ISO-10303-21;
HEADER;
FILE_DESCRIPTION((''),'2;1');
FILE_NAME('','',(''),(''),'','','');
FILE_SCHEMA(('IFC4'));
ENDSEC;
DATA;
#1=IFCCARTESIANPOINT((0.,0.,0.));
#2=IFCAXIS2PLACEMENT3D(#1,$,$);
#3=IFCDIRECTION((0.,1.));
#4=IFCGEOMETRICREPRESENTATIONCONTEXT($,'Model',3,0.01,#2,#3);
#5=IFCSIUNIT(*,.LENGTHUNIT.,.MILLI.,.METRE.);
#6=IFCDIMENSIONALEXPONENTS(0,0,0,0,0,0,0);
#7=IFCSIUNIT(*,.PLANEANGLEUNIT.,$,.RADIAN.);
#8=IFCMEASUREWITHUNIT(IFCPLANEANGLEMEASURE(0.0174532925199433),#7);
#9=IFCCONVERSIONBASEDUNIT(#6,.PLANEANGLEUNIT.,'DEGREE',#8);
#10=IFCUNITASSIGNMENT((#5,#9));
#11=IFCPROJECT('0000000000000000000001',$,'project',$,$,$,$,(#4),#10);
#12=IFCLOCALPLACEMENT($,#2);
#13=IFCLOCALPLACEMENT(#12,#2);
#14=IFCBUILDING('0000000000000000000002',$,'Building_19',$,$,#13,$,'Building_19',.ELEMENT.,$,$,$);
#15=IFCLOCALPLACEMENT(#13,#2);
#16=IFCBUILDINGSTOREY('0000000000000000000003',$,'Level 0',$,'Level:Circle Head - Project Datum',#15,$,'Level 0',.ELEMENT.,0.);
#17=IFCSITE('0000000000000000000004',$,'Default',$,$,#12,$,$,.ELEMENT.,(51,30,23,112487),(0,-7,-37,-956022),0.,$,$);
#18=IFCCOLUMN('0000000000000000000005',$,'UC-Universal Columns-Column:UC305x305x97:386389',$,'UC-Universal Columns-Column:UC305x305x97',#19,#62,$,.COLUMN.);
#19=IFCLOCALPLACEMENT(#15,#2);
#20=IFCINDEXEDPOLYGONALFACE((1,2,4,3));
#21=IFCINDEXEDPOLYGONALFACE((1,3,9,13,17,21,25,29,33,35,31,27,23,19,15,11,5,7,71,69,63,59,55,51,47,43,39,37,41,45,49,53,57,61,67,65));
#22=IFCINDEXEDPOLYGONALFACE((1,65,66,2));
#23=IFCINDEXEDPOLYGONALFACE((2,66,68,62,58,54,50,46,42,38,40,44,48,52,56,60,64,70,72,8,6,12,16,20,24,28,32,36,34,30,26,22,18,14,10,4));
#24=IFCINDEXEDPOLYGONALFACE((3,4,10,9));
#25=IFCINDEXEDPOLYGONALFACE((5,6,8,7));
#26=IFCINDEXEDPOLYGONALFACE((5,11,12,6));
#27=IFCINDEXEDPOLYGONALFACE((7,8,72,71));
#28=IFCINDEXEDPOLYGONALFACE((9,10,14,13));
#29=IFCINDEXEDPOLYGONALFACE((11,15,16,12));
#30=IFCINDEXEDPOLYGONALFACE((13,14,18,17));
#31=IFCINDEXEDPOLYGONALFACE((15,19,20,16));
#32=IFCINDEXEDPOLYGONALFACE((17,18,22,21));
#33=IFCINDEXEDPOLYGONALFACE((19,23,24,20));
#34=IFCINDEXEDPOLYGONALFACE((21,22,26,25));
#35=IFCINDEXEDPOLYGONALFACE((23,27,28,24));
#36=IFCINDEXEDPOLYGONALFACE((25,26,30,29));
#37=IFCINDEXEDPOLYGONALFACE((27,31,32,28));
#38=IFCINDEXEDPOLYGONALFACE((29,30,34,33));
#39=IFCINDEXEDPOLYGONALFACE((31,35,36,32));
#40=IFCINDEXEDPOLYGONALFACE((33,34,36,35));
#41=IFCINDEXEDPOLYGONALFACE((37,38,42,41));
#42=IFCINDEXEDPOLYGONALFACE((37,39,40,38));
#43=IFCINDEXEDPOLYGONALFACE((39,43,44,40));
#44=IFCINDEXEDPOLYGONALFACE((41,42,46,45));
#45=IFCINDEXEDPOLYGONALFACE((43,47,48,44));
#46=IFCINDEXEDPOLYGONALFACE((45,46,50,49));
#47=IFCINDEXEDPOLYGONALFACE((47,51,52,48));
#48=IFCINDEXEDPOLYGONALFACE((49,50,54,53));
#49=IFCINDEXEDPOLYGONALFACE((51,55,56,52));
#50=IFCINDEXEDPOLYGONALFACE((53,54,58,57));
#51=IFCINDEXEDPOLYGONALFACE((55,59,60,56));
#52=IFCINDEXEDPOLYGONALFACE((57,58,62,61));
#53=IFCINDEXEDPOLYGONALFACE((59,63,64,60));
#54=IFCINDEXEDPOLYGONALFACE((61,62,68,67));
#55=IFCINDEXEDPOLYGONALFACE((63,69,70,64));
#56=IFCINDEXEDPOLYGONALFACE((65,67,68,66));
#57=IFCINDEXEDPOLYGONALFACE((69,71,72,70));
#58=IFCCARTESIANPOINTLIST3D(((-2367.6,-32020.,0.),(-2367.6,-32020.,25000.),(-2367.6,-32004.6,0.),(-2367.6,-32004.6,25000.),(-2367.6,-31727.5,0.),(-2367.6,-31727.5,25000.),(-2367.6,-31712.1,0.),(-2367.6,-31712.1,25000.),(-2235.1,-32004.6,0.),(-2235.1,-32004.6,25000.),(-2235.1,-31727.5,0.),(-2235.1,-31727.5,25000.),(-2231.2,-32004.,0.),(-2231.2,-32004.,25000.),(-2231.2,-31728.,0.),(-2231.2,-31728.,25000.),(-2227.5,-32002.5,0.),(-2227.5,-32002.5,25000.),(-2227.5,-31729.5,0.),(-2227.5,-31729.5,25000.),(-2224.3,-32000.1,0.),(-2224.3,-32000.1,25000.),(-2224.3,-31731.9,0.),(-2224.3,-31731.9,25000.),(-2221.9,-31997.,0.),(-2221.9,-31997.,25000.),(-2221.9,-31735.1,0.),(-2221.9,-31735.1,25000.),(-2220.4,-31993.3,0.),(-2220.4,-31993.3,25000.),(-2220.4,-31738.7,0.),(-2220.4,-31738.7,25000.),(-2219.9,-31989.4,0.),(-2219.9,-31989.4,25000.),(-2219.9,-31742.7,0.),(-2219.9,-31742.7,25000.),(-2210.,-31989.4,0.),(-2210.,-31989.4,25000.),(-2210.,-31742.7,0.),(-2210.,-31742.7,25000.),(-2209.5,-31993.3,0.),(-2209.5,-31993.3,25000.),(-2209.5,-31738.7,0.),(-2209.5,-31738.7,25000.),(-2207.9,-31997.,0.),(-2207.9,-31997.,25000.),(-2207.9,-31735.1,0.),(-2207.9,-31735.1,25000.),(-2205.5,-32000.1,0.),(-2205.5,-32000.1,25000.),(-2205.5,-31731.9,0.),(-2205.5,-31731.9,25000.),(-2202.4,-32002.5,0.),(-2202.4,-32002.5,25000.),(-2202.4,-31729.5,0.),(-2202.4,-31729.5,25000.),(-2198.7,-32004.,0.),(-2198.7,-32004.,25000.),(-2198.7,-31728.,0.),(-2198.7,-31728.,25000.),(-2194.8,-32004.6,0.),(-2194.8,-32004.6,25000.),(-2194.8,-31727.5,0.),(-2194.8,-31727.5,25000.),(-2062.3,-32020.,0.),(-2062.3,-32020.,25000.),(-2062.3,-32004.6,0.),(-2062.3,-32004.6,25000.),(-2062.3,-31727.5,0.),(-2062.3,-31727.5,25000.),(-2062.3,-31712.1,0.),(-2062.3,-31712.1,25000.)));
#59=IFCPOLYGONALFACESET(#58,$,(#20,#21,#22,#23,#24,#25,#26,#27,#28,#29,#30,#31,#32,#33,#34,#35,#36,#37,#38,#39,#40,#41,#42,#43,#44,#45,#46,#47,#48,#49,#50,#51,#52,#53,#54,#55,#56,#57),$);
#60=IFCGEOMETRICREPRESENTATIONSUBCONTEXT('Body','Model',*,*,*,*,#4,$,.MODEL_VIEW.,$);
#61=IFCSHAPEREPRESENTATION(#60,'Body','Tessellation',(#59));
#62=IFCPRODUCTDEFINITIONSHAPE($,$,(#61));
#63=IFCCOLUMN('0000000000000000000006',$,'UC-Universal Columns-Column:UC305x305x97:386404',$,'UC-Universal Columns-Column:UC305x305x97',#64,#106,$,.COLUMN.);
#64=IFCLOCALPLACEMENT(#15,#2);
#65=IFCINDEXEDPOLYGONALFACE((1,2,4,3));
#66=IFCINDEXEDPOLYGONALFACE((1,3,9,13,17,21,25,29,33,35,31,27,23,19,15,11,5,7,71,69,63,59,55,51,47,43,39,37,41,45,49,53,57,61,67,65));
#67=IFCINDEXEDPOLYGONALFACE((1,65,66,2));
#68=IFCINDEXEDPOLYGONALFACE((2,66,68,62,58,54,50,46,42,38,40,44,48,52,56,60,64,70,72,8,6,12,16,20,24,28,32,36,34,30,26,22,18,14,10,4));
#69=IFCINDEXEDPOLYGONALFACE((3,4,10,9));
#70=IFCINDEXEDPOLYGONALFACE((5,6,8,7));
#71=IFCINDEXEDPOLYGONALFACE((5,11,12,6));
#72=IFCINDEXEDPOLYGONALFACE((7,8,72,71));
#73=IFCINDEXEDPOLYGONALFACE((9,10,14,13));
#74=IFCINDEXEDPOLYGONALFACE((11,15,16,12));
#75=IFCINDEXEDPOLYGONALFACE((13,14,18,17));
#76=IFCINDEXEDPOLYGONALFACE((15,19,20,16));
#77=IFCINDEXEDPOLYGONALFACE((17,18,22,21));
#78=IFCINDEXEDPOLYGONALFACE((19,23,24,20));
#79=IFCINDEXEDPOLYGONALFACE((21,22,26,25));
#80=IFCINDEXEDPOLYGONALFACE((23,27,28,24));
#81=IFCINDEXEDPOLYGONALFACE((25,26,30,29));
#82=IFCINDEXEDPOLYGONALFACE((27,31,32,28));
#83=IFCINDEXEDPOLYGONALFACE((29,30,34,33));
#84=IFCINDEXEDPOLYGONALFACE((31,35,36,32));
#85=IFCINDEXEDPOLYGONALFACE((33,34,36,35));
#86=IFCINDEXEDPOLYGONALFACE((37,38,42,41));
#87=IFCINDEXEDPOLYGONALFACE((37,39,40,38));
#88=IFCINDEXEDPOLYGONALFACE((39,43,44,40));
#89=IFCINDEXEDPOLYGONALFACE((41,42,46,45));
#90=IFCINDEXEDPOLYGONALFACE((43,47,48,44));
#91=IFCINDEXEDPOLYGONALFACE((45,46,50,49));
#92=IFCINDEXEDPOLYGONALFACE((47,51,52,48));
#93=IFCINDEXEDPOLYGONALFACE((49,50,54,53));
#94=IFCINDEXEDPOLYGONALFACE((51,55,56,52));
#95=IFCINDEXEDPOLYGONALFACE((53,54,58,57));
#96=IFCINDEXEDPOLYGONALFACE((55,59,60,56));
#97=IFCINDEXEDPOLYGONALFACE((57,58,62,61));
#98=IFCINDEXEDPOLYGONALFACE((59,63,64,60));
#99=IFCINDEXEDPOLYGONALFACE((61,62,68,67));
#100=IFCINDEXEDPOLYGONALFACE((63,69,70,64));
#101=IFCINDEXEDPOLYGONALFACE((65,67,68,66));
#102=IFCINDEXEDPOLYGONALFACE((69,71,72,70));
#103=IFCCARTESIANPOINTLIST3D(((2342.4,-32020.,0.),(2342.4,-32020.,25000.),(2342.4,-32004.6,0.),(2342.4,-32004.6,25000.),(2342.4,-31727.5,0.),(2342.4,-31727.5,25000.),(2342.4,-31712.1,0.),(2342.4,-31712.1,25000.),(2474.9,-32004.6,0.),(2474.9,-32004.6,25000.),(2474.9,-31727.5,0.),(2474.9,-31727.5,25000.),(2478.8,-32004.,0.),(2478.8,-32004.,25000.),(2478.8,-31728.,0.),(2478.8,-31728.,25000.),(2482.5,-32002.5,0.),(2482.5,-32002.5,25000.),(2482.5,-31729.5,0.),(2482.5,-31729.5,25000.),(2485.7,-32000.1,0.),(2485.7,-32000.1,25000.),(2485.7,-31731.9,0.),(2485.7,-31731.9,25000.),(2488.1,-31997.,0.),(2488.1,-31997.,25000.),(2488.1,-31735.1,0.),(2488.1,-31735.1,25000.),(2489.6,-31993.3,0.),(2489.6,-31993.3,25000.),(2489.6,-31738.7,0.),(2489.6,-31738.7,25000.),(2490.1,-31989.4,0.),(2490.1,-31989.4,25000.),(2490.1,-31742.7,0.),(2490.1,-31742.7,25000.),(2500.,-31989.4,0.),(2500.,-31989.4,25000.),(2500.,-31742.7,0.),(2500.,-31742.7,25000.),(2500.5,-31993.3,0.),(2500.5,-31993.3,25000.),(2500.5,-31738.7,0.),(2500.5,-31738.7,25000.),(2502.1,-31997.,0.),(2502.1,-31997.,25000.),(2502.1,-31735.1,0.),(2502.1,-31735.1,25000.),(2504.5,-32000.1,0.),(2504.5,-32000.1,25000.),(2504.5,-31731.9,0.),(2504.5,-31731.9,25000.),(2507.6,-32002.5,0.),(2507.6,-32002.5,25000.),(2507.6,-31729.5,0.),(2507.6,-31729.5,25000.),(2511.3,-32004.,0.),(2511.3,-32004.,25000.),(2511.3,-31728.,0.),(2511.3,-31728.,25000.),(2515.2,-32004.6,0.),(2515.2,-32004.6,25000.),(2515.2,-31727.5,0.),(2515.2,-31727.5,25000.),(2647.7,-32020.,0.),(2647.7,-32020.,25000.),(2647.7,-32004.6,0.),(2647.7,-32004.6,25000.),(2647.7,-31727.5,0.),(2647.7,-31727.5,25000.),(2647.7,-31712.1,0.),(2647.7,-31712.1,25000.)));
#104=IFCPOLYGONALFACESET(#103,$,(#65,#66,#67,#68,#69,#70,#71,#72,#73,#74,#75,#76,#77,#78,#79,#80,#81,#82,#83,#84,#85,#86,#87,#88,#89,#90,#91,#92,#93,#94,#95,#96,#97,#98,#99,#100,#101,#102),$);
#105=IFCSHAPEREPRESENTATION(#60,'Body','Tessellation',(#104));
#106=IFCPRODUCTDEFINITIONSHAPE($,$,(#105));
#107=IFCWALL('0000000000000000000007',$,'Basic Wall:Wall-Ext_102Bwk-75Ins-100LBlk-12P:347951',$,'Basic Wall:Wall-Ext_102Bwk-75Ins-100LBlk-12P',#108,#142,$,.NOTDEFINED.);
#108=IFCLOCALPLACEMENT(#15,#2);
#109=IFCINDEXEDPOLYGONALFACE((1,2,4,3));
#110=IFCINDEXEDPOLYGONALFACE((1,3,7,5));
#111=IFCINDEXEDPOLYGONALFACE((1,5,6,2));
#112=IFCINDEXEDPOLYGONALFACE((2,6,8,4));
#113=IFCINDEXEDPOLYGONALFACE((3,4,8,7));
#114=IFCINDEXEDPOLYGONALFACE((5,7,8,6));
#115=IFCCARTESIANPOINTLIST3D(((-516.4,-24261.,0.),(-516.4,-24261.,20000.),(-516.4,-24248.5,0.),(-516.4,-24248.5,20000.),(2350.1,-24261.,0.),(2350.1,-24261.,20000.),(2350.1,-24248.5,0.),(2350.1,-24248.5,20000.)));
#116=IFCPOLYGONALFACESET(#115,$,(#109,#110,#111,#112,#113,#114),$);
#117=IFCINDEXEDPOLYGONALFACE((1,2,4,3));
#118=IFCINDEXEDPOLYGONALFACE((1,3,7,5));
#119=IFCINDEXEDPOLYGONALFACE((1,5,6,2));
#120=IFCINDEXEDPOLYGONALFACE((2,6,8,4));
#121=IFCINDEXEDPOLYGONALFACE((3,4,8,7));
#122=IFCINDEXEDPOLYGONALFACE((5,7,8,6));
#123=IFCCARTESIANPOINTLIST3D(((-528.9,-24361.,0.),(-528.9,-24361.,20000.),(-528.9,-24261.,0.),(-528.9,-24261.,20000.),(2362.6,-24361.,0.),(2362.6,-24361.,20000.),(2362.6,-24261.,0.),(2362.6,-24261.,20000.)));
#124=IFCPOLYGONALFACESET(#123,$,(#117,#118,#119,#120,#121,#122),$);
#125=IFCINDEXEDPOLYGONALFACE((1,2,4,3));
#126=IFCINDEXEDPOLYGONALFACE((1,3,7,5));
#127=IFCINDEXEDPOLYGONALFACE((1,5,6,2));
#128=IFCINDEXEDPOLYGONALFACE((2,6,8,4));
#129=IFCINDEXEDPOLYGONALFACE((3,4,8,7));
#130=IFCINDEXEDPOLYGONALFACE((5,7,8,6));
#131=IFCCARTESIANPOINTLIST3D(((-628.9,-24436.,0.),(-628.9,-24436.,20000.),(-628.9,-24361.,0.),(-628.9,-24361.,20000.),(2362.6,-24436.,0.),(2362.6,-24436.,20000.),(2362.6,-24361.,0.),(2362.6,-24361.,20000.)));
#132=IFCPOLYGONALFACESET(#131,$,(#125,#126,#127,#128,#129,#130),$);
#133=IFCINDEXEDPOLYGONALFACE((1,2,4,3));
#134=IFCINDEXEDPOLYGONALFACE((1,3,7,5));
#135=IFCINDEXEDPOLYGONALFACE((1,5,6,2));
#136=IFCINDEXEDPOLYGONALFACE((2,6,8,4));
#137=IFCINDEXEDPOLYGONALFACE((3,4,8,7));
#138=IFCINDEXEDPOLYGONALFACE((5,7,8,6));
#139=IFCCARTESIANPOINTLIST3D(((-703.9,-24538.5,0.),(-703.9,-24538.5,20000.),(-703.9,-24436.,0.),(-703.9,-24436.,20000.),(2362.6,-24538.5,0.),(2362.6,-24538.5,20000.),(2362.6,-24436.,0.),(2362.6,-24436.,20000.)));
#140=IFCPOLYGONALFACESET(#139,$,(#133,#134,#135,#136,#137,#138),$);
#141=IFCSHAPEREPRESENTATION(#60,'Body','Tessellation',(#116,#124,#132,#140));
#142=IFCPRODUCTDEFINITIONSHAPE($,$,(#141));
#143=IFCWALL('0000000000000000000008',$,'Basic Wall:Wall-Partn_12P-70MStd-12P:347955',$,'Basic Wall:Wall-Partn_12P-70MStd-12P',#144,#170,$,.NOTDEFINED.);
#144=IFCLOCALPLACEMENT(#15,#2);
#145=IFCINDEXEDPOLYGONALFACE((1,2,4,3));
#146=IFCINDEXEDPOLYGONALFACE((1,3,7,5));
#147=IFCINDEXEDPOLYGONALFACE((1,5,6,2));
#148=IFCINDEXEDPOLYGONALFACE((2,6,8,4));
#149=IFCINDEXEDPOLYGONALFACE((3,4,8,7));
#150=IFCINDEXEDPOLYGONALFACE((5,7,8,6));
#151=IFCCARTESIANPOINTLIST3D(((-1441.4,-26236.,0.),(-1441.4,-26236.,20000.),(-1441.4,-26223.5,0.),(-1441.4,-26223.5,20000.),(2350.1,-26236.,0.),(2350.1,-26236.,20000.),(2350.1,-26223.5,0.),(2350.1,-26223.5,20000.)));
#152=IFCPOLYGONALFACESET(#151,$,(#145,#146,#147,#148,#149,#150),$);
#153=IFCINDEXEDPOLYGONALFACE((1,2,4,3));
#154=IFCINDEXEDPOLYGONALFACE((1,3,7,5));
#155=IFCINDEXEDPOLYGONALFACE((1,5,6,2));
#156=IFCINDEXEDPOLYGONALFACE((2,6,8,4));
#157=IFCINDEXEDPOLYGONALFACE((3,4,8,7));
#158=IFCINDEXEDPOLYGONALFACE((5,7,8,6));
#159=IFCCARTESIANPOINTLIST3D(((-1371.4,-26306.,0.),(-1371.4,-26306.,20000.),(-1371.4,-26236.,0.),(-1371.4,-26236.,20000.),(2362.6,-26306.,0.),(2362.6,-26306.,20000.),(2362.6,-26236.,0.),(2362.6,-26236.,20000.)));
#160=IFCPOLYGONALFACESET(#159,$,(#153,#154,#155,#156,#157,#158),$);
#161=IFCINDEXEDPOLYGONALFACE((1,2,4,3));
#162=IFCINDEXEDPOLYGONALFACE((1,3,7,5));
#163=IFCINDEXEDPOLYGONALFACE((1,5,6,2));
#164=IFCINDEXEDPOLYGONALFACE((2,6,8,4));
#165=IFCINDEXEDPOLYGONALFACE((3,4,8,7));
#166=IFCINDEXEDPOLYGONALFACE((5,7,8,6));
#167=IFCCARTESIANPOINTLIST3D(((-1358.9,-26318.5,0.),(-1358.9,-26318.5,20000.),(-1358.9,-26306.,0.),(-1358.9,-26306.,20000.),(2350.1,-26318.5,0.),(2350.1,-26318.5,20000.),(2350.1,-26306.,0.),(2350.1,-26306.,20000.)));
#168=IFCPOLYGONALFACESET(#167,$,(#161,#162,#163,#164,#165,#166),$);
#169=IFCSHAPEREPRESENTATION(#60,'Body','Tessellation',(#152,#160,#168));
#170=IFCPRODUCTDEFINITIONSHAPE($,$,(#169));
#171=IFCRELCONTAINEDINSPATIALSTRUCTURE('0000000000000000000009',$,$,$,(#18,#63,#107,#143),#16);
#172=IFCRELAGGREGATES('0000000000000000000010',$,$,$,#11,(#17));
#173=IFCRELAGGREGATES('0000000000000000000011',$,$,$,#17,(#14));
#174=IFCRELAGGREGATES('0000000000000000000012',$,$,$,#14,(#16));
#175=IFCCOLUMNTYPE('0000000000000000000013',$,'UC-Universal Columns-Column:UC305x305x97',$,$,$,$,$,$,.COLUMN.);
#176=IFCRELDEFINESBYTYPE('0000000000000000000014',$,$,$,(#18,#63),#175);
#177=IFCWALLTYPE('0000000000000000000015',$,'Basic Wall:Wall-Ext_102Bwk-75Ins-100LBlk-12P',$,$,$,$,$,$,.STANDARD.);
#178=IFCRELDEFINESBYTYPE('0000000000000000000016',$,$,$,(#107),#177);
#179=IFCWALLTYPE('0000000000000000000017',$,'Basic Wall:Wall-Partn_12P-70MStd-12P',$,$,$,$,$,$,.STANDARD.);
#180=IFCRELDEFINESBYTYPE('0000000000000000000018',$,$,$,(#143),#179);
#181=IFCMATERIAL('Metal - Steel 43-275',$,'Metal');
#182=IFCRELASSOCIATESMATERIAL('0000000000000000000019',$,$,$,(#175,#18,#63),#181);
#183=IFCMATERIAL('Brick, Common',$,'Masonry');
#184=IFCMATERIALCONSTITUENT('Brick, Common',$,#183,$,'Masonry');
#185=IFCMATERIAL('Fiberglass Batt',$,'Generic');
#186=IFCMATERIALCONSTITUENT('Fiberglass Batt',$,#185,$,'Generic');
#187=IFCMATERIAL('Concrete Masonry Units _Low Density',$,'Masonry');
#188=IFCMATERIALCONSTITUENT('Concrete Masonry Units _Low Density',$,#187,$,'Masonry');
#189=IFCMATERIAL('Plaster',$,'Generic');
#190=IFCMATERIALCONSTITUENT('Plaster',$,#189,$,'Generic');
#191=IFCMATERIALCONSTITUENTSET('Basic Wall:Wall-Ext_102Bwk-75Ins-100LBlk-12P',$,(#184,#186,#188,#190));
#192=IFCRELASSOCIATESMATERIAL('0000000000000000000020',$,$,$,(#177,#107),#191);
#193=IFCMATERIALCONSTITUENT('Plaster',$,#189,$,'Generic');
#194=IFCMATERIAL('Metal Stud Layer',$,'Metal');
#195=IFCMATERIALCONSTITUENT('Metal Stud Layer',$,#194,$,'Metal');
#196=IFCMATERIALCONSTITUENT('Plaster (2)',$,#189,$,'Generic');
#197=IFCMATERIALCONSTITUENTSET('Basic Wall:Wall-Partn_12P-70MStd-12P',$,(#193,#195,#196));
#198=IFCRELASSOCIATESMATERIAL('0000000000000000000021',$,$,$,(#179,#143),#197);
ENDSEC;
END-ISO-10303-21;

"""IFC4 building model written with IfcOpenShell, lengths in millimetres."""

from ifc_helpers import new_model, entity, si_unit, converted_unit, direction, frame, origin, place, context, subcontext, project, spatial, line, arc, indexed_curve, outline, extrude, source, transform, mapped, material, constituent, constituent_set, type_object, type_shapes, element, save


model = new_model("IFC4")

# Units and contexts
model_context = context("Model", 3, precision=0.01, world=origin(), true_north=direction((0.0, 1.0)))
body_context = subcontext(model_context, "Body", "Model", "MODEL_VIEW")
ifc_project = project(units=[si_unit("LENGTHUNIT", "METRE", prefix="MILLI"), converted_unit("PLANEANGLEUNIT", "DEGREE", entity("IfcPlaneAngleMeasure", 0.0174532925199433), si_unit("PLANEANGLEUNIT", "RADIAN"), dimensions=[0, 0, 0, 0, 0, 0, 0])], contexts=[model_context])

# Site, building, storey
site_placement = place(None, origin())
site = spatial("IfcSite", under=ifc_project, at=site_placement, Name="Default", CompositionType="ELEMENT", RefLatitude=(51, 30, 23, 112487), RefLongitude=(0, -7, -37, -956022), RefElevation=0.0)
building_placement = place(site_placement, origin())
building = spatial("IfcBuilding", under=site, at=building_placement, Name="Building_19", LongName="Building_19", CompositionType="ELEMENT")
storey_placement = place(building_placement, origin())
storey = spatial("IfcBuildingStorey", under=building, at=storey_placement, Name="Level 0", ObjectType="Level:Circle Head - Project Datum", LongName="Level 0", CompositionType="ELEMENT", Elevation=0.0)

# Columns
ifc_material_1 = material(Name="Metal - Steel 43-275", Category="Metal")
column_type = type_object("IfcColumnType", Name="UC-Universal Columns-Column:UC305x305x97", PredefinedType="COLUMN", material=ifc_material_1)
shared_shape_1 = source(origin(), body_context, "Body", "SweptSolid", [
    extrude(outline(indexed_curve([(-152.7, -153.9), (152.7, -153.9), (152.7, -138.6), (20.2, -138.6), (9.4, -134.1), (4.9, -123.3), (4.9, 123.3), (9.4, 134.1), (20.1, 138.6), (152.7, 138.6), (152.7, 153.9), (-152.7, 153.9), (-152.7, 138.6), (-20.2, 138.6), (-9.4, 134.1), (-5.0, 123.3), (-5.0, -123.3), (-9.4, -134.1), (-20.2, -138.6), (-152.7, -138.6)], segments=[line(1, 2, 3, 4), arc(4, 5, 6), line(6, 7), arc(7, 8, 9), line(9, 10, 11, 12, 13, 14), arc(14, 15, 16), line(16, 17), arc(17, 18, 19), line(19, 20, 1)], self_intersect=False)), frame((0.0, 0.0, 0.0), z_axis=(0.0, 0.0, 1.0), x_axis=(-1.0, 0.0, 0.0)), (0.0, 0.0, 1.0), 25000.0),
])
type_shapes(column_type, [shared_shape_1])
for number, where, name in (
    (1, (-2214.9, -31866.0, 0.0), "UC-Universal Columns-Column:UC305x305x97:386389"),
    (2, (2495.1, -31866.0, 0.0), "UC-Universal Columns-Column:UC305x305x97:386404"),
):
    element("IfcColumn", number, at=place(storey_placement, frame(where)), inside=storey, type_object=column_type, material=ifc_material_1, Name=name, ObjectType="UC-Universal Columns-Column:UC305x305x97", PredefinedType="COLUMN", context=body_context, shape_type="MappedRepresentation", body=[
        mapped(shared_shape_1, transform((0.0, 0.0, 0.0), scale=1.0)),
    ])

# Shared definitions
ifc_material_2 = material(Name="Brick, Common", Category="Masonry")
ifc_constituent_1 = constituent(ifc_material_2, Name="Brick, Common", Category="Masonry")
ifc_material_3 = material(Name="Fiberglass Batt", Category="Generic")
ifc_constituent_2 = constituent(ifc_material_3, Name="Fiberglass Batt", Category="Generic")
ifc_material_4 = material(Name="Concrete Masonry Units _Low Density", Category="Masonry")
ifc_constituent_3 = constituent(ifc_material_4, Name="Concrete Masonry Units _Low Density", Category="Masonry")
ifc_material_5 = material(Name="Plaster", Category="Generic")
ifc_constituent_4 = constituent(ifc_material_5, Name="Plaster", Category="Generic")
ifc_constituent_set_1 = constituent_set(constituents=[ifc_constituent_1, ifc_constituent_2, ifc_constituent_3, ifc_constituent_4], Name="Basic Wall:Wall-Ext_102Bwk-75Ins-100LBlk-12P")
wall_type_1 = type_object("IfcWallType", Name="Basic Wall:Wall-Ext_102Bwk-75Ins-100LBlk-12P", PredefinedType="STANDARD", material=ifc_constituent_set_1)

# Wall
wall_1_placement = place(storey_placement, frame((-516.4, -24393.5, 0.0)))
element("IfcWall", 3, at=wall_1_placement, inside=storey, type_object=wall_type_1, material=ifc_constituent_set_1, Name="Basic Wall:Wall-Ext_102Bwk-75Ins-100LBlk-12P:347951", ObjectType="Basic Wall:Wall-Ext_102Bwk-75Ins-100LBlk-12P", PredefinedType="NOTDEFINED", context=body_context, shape_type="SweptSolid", body=[
    extrude(outline(indexed_curve([(-6.3, -1433.2), (6.2, -1433.2), (6.3, 1433.2), (-6.2, 1433.2), (-6.3, -1433.2)], self_intersect=False)), frame((1433.2, 138.8, 0.0), z_axis=(0.0, 0.0, 1.0), x_axis=(0.0, -1.0, 0.0)), (0.0, 0.0, 1.0), 20000.0),
    extrude(outline(indexed_curve([(-1445.7, -50.0), (1445.7, -50.0), (1445.7, 50.0), (-1445.7, 50.0), (-1445.7, -50.0)], self_intersect=False)), frame((1433.2, 82.5, 0.0)), (0.0, 0.0, 1.0), 20000.0),
    extrude(outline(indexed_curve([(-1495.7, -37.5), (1495.7, -37.5), (1495.7, 37.5), (-1495.7, 37.5), (-1495.7, -37.5)], self_intersect=False)), frame((1383.2, -5.0, 0.0)), (0.0, 0.0, 1.0), 20000.0),
    extrude(outline(indexed_curve([(-51.3, -1533.2), (51.2, -1533.2), (51.3, 1533.2), (-51.2, 1533.2), (-51.3, -1533.2)], self_intersect=False)), frame((1345.7, -93.8, 0.0), z_axis=(0.0, 0.0, 1.0), x_axis=(0.0, 1.0, 0.0)), (0.0, 0.0, 1.0), 20000.0),
])

# Shared definitions
ifc_constituent_5 = constituent(ifc_material_5, Name="Plaster", Category="Generic")
ifc_material_6 = material(Name="Metal Stud Layer", Category="Metal")
ifc_constituent_6 = constituent(ifc_material_6, Name="Metal Stud Layer", Category="Metal")
ifc_constituent_7 = constituent(ifc_material_5, Name="Plaster (2)", Category="Generic")
ifc_constituent_set_2 = constituent_set(constituents=[ifc_constituent_5, ifc_constituent_6, ifc_constituent_7], Name="Basic Wall:Wall-Partn_12P-70MStd-12P")
wall_type_2 = type_object("IfcWallType", Name="Basic Wall:Wall-Partn_12P-70MStd-12P", PredefinedType="STANDARD", material=ifc_constituent_set_2)

# Wall
wall_2_placement = place(storey_placement, frame((-1358.9, -26271.0, 0.0)))
element("IfcWall", 4, at=wall_2_placement, inside=storey, type_object=wall_type_2, material=ifc_constituent_set_2, Name="Basic Wall:Wall-Partn_12P-70MStd-12P:347955", ObjectType="Basic Wall:Wall-Partn_12P-70MStd-12P", PredefinedType="NOTDEFINED", context=body_context, shape_type="SweptSolid", body=[
    extrude(outline(indexed_curve([(-6.3, -1895.7), (6.2, -1895.7), (6.3, 1895.7), (-6.2, 1895.7), (-6.3, -1895.7)], self_intersect=False)), frame((1813.2, 41.2, 0.0), z_axis=(0.0, 0.0, 1.0), x_axis=(0.0, -1.0, 0.0)), (0.0, 0.0, 1.0), 20000.0),
    extrude(outline(indexed_curve([(-1867.0, -35.0), (1867.0, -35.0), (1867.0, 35.0), (-1867.0, 35.0), (-1867.0, -35.0)], self_intersect=False)), frame((1854.5, 0.0, 0.0)), (0.0, 0.0, 1.0), 20000.0),
    extrude(outline(indexed_curve([(-6.3, -1854.5), (6.2, -1854.5), (6.3, 1854.5), (-6.2, 1854.5), (-6.3, -1854.5)], self_intersect=False)), frame((1854.5, -41.3, 0.0), z_axis=(0.0, 0.0, 1.0), x_axis=(0.0, 1.0, 0.0)), (0.0, 0.0, 1.0), 20000.0),
])

save(model, "model.ifc")
